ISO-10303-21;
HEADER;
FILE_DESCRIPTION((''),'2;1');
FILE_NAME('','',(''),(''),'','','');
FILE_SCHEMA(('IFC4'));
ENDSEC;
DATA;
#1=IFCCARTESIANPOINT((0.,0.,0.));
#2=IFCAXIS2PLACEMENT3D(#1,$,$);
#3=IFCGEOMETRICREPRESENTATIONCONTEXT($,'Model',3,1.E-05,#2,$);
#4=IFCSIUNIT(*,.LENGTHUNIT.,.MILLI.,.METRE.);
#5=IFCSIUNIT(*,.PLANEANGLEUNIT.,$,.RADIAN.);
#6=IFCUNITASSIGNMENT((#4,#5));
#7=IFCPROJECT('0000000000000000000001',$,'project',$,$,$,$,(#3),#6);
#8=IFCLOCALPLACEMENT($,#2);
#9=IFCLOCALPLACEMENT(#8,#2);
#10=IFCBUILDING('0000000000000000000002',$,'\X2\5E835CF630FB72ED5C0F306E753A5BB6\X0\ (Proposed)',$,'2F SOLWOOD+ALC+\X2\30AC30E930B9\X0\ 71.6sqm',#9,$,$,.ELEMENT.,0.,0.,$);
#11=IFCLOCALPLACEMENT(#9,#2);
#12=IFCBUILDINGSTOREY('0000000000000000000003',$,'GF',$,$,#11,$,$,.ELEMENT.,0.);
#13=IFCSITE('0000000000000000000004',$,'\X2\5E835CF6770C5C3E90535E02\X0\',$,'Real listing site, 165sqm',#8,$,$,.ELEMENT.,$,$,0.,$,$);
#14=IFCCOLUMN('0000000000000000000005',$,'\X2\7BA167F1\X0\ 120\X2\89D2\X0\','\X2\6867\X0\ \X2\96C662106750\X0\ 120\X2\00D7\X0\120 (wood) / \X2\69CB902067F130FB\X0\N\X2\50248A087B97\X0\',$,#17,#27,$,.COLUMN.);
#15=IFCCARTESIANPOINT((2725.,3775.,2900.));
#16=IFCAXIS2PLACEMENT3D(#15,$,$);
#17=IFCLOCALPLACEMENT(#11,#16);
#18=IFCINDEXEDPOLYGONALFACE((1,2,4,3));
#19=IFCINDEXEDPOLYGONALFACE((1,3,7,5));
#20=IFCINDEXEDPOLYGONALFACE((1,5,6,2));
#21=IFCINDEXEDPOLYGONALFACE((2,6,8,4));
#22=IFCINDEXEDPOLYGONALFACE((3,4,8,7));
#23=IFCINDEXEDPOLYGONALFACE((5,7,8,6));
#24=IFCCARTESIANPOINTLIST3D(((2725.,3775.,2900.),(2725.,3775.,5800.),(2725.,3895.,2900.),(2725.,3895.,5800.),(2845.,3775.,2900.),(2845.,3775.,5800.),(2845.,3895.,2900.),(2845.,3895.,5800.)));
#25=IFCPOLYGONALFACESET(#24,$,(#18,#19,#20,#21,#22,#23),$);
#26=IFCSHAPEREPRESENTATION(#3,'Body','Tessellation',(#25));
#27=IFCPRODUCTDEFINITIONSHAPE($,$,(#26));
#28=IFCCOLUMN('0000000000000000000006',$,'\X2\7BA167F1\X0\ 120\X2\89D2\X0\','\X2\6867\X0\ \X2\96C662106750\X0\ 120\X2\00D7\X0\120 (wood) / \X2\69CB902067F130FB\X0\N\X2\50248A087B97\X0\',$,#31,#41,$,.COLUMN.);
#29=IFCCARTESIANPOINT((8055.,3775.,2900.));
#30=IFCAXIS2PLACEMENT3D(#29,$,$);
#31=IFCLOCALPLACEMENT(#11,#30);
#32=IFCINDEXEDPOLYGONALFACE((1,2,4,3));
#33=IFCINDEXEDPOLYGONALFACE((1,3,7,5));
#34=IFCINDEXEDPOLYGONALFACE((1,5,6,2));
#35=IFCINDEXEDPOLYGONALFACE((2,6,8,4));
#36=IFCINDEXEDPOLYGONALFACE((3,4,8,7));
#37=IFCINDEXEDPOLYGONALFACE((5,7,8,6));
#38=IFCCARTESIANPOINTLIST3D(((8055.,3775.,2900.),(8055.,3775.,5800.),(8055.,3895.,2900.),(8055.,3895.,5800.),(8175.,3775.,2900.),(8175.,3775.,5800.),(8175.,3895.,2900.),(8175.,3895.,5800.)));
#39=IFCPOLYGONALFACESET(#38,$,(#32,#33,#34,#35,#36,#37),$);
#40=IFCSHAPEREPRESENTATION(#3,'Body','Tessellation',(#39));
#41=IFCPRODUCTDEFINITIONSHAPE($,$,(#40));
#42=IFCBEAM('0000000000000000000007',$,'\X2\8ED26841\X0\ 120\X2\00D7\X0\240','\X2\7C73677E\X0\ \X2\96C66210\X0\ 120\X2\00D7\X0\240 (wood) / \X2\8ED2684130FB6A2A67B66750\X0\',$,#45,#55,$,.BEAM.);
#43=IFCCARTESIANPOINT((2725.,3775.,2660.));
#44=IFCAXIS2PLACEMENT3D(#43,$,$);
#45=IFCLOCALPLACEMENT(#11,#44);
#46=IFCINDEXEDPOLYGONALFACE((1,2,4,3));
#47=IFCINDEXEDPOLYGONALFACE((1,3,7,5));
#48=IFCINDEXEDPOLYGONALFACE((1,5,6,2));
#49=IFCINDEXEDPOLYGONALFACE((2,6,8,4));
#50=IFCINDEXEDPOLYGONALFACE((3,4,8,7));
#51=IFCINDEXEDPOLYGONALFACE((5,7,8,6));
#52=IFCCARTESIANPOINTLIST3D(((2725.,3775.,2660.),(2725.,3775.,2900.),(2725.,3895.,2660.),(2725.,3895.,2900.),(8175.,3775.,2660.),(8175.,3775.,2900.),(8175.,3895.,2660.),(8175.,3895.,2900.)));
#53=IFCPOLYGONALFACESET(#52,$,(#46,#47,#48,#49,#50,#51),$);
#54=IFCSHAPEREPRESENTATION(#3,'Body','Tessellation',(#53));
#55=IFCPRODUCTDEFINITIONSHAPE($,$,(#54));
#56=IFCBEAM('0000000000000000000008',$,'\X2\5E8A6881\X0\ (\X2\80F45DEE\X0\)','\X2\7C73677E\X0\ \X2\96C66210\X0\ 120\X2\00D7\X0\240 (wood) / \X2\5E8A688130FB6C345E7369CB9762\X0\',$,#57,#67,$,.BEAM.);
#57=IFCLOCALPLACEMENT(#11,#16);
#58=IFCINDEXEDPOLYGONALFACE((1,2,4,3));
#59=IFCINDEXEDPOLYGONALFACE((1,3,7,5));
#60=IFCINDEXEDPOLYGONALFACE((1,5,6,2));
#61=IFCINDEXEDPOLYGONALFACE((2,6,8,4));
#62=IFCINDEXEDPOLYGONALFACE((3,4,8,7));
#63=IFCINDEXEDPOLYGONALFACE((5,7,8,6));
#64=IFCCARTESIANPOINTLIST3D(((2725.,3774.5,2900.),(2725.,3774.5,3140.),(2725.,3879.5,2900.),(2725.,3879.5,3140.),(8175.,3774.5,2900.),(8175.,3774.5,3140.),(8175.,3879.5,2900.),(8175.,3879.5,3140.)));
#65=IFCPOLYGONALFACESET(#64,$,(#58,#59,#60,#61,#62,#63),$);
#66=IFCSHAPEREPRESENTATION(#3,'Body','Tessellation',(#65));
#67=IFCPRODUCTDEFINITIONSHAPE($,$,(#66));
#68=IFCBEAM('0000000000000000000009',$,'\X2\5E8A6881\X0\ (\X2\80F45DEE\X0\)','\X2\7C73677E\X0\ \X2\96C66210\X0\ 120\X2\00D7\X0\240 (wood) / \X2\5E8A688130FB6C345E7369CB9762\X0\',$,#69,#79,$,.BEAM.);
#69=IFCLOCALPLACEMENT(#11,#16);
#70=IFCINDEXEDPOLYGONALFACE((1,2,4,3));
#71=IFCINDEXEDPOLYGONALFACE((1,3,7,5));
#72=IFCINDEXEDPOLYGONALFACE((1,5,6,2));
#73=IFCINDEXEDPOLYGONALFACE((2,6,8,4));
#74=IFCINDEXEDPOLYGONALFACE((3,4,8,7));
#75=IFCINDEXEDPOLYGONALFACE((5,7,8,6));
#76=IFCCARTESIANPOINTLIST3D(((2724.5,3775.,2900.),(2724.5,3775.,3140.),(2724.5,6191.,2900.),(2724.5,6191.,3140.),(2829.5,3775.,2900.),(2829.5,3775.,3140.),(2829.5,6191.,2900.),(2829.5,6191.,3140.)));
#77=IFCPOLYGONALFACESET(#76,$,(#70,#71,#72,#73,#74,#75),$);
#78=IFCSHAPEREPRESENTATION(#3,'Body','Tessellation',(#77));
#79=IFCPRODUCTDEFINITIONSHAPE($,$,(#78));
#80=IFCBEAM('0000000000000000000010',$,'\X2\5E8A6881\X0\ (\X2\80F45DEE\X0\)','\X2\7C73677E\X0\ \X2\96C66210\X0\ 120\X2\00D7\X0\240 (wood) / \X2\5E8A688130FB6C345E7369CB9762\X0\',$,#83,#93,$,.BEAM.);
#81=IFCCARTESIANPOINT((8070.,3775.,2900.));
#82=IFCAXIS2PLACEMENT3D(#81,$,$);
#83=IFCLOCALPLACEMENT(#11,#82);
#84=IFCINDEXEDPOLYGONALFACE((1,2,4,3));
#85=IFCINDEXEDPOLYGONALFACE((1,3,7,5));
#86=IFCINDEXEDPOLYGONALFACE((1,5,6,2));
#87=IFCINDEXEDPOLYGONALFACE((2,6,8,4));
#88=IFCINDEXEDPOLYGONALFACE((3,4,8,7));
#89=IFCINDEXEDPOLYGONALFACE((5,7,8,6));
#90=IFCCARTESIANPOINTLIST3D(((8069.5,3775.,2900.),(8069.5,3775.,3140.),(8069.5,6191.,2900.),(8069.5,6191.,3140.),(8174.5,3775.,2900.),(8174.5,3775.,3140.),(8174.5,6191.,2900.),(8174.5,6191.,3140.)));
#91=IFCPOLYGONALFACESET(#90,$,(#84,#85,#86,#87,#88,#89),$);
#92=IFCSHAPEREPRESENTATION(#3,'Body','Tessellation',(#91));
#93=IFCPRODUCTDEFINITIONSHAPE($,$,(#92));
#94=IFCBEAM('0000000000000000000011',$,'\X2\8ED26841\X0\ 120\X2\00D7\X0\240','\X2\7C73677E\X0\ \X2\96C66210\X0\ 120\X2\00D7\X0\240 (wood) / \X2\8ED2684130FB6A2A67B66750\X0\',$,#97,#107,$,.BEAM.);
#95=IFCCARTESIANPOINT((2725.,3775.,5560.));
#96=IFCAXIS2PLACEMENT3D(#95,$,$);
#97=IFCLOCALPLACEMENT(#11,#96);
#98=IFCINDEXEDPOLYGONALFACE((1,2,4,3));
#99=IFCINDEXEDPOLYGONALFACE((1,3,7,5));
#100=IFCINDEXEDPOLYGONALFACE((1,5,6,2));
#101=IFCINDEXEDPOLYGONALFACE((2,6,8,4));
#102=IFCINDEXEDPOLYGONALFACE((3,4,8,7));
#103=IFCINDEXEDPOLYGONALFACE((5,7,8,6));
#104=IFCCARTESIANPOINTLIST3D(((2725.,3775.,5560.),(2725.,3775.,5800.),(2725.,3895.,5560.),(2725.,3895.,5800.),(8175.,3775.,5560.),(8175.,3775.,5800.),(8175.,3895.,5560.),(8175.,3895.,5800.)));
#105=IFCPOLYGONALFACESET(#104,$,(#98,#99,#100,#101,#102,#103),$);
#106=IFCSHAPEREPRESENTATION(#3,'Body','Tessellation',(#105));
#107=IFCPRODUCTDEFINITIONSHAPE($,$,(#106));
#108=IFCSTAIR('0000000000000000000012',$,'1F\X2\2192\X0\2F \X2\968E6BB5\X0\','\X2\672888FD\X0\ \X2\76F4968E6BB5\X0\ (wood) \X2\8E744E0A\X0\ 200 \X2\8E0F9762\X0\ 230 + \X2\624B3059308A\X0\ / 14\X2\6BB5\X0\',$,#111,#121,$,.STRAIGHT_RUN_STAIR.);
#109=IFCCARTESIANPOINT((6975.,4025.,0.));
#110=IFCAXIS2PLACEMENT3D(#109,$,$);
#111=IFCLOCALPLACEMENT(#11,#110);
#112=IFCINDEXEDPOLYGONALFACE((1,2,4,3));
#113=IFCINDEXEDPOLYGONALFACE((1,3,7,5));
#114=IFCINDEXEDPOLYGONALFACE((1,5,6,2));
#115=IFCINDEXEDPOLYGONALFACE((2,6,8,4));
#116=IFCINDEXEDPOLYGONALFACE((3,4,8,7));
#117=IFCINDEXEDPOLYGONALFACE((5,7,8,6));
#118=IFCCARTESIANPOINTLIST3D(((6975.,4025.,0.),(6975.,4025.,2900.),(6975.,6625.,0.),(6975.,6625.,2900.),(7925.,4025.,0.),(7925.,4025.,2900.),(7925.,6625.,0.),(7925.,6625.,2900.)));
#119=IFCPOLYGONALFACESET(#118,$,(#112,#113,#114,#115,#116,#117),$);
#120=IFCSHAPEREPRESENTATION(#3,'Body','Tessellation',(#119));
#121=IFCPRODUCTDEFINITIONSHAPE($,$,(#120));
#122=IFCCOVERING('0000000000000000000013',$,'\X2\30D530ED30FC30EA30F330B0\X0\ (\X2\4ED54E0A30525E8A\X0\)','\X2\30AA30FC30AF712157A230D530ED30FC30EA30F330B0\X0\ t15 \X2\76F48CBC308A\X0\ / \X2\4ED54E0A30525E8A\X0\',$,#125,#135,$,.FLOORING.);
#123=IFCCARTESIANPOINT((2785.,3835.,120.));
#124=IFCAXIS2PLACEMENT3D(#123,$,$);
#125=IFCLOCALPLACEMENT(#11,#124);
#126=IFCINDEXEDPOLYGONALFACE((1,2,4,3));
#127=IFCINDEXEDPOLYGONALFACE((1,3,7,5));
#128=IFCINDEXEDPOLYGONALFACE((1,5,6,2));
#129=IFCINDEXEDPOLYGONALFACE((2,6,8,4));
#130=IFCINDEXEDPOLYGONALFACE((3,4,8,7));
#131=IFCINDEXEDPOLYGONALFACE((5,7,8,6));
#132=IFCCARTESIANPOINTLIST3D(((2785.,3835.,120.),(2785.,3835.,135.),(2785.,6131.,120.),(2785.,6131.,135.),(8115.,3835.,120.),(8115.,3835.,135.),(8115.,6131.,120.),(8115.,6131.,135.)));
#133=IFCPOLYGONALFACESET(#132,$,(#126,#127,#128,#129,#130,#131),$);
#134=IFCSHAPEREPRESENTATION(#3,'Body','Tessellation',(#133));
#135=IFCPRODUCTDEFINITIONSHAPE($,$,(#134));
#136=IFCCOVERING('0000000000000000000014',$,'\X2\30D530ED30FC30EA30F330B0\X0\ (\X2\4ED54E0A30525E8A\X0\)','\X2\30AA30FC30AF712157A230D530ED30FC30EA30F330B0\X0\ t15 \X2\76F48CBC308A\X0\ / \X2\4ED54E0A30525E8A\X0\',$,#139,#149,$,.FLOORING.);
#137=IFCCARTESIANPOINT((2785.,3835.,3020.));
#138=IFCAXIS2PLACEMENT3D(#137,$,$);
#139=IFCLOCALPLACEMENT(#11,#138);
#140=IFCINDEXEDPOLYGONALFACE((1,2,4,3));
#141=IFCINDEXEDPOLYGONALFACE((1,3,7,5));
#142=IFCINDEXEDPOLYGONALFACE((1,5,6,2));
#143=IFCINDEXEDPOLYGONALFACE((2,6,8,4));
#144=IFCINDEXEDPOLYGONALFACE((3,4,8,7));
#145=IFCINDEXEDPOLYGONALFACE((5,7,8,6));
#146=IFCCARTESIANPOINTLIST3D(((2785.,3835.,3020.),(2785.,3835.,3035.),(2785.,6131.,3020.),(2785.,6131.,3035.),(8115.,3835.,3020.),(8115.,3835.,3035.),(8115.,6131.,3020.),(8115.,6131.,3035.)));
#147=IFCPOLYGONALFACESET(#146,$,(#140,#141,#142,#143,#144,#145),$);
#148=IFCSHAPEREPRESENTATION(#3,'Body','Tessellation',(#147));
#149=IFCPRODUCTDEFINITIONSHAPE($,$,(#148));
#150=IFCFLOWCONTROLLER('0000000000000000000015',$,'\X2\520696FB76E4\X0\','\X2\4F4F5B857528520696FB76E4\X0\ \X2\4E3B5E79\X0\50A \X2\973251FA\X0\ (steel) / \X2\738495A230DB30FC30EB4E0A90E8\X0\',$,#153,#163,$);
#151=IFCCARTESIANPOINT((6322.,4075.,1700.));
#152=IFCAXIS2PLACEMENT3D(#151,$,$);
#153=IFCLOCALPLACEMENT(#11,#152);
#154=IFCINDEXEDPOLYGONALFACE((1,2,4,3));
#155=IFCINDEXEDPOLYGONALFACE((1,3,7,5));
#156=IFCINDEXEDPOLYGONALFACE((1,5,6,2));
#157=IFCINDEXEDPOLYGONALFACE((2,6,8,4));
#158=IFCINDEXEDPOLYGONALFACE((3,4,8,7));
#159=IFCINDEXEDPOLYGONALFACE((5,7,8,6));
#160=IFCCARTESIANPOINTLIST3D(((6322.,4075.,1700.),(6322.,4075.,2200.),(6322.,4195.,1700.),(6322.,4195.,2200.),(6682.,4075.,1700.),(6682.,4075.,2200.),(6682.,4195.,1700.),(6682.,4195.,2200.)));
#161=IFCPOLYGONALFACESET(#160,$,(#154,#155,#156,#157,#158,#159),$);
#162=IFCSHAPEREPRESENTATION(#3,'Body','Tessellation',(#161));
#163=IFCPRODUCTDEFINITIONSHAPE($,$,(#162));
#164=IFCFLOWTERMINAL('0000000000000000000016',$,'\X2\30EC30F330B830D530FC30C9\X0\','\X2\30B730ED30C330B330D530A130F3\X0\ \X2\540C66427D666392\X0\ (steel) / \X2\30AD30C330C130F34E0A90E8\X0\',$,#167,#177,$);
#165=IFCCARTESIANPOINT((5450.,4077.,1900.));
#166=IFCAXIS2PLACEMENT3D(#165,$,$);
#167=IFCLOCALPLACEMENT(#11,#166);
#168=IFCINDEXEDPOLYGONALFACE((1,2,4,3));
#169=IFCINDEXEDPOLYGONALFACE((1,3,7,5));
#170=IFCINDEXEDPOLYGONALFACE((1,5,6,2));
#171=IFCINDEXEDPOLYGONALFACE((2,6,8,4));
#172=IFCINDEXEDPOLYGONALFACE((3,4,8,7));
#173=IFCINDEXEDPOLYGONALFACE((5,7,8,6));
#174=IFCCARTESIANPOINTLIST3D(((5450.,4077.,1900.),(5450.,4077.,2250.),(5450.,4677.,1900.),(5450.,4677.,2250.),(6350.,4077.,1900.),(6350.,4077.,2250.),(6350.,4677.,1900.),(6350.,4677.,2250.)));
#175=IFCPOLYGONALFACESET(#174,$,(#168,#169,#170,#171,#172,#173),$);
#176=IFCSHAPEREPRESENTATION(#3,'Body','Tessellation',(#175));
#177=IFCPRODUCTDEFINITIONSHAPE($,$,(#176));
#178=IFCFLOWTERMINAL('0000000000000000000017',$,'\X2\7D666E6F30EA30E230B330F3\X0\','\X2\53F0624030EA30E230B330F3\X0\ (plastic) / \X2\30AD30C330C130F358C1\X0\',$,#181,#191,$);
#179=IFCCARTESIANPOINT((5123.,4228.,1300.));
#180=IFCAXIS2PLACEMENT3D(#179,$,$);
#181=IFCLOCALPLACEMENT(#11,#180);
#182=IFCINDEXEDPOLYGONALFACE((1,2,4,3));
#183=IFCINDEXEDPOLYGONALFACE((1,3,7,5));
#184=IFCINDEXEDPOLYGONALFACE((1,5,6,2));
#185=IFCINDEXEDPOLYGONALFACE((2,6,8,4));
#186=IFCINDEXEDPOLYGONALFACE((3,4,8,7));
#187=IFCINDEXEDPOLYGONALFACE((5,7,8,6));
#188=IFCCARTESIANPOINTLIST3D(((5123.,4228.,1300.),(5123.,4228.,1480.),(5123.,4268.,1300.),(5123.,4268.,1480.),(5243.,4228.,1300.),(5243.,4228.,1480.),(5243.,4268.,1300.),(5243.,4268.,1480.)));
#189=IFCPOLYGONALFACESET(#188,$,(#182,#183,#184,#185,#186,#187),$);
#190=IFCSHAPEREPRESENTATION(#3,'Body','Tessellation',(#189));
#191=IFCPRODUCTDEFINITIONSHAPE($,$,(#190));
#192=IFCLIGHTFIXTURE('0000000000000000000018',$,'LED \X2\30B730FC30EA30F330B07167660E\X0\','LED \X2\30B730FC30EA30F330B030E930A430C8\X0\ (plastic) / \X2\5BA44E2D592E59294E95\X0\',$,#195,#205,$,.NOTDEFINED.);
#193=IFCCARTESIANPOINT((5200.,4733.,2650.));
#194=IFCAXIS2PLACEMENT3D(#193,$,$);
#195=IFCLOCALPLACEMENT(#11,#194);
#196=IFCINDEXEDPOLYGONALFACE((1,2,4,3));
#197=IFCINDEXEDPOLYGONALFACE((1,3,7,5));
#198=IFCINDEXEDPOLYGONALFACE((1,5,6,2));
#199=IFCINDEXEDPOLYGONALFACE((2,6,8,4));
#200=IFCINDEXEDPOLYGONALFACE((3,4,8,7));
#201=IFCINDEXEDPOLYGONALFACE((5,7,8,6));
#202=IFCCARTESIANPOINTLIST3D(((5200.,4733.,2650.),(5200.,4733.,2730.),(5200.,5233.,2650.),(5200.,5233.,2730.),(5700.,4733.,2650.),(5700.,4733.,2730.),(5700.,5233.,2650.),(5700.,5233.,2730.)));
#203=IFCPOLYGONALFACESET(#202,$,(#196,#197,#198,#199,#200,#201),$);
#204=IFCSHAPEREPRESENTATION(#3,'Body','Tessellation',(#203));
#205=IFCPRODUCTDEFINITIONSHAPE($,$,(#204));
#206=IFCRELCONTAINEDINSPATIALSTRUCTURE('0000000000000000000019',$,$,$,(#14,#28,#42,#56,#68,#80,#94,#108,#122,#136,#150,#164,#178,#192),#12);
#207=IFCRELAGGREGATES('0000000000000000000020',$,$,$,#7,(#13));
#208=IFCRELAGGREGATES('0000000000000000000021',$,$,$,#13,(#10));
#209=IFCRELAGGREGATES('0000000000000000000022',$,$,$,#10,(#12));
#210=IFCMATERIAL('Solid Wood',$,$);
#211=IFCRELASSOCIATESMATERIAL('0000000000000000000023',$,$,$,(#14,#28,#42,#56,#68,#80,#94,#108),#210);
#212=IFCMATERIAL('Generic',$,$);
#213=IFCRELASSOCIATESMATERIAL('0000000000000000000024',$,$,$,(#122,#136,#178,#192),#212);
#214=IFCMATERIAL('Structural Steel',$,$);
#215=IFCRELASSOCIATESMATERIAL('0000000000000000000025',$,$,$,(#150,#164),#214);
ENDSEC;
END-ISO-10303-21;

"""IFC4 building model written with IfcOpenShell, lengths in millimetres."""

from ifc_helpers import new_model, si_unit, frame, frame_2d, origin, place, context, project, spatial, rectangle, extrude, material, element, save


model = new_model("IFC4")

# Units and contexts
model_context = context("Model", 3, precision=1e-05, world=origin())
ifc_project = project(units=[si_unit("LENGTHUNIT", "METRE", prefix="MILLI"), si_unit("PLANEANGLEUNIT", "RADIAN")], contexts=[model_context])

# Site, building, storey
site_placement = place(None, origin())
site = spatial("IfcSite", under=ifc_project, at=site_placement, Name="広島県尾道市", ObjectType="Real listing site, 165sqm", CompositionType="ELEMENT", RefElevation=0.0)
building_placement = place(site_placement, origin())
building = spatial("IfcBuilding", under=site, at=building_placement, Name="広島・狭小の町家 (Proposed)", ObjectType="2F SOLWOOD+ALC+ガラス 71.6sqm", CompositionType="ELEMENT", ElevationOfRefHeight=0.0, ElevationOfTerrain=0.0)
storey_placement = place(building_placement, origin())
storey = spatial("IfcBuildingStorey", under=building, at=storey_placement, Name="GF", CompositionType="ELEMENT", Elevation=0.0)

# Columns
ifc_material_1 = material(Name="Solid Wood")
column_1_placement = place(storey_placement, frame((2725.0, 3775.0, 2900.0)))
element("IfcColumn", 1, at=column_1_placement, inside=storey, material=ifc_material_1, Name="管柱 120角", Description="桧 集成材 120×120 (wood) / 構造柱・N値計算", PredefinedType="COLUMN", context=model_context, shape_type="SweptSolid", body=[
    extrude(rectangle(XDim=120.0, YDim=120.0, at=frame_2d((60.0, 60.0))), frame((2725.0, 3775.0, 2900.0)), (0.0, 0.0, 1.0), 2900.0),
])
column_2_placement = place(storey_placement, frame((8055.0, 3775.0, 2900.0)))
element("IfcColumn", 2, at=column_2_placement, inside=storey, material=ifc_material_1, Name="管柱 120角", Description="桧 集成材 120×120 (wood) / 構造柱・N値計算", PredefinedType="COLUMN", context=model_context, shape_type="SweptSolid", body=[
    extrude(rectangle(XDim=120.0, YDim=120.0, at=frame_2d((60.0, 60.0))), frame((8055.0, 3775.0, 2900.0)), (0.0, 0.0, 1.0), 2900.0),
])

# Beams
beam_1_placement = place(storey_placement, frame((2725.0, 3775.0, 2660.0)))
element("IfcBeam", 3, at=beam_1_placement, inside=storey, material=ifc_material_1, Name="軒桁 120×240", Description="米松 集成 120×240 (wood) / 軒桁・横架材", PredefinedType="BEAM", context=model_context, shape_type="SweptSolid", body=[
    extrude(rectangle(XDim=5450.0, YDim=120.0, at=frame_2d((2725.0, 60.0))), frame((2725.0, 3775.0, 2660.0)), (0.0, 0.0, 1.0), 240.0),
])
beam_2_placement = place(storey_placement, frame((2725.0, 3775.0, 2900.0)))
element("IfcBeam", 4, at=beam_2_placement, inside=storey, material=ifc_material_1, Name="床梁 (胴差)", Description="米松 集成 120×240 (wood) / 床梁・水平構面", PredefinedType="BEAM", context=model_context, shape_type="SweptSolid", body=[
    extrude(rectangle(XDim=5450.0, YDim=105.0, at=frame_2d((2725.0, 52.0))), frame((2725.0, 3775.0, 2900.0)), (0.0, 0.0, 1.0), 240.0),
])
beam_3_placement = place(storey_placement, frame((2725.0, 3775.0, 2900.0)))
element("IfcBeam", 5, at=beam_3_placement, inside=storey, material=ifc_material_1, Name="床梁 (胴差)", Description="米松 集成 120×240 (wood) / 床梁・水平構面", PredefinedType="BEAM", context=model_context, shape_type="SweptSolid", body=[
    extrude(rectangle(XDim=105.0, YDim=2416.0, at=frame_2d((52.0, 1208.0))), frame((2725.0, 3775.0, 2900.0)), (0.0, 0.0, 1.0), 240.0),
])
beam_4_placement = place(storey_placement, frame((8070.0, 3775.0, 2900.0)))
element("IfcBeam", 6, at=beam_4_placement, inside=storey, material=ifc_material_1, Name="床梁 (胴差)", Description="米松 集成 120×240 (wood) / 床梁・水平構面", PredefinedType="BEAM", context=model_context, shape_type="SweptSolid", body=[
    extrude(rectangle(XDim=105.0, YDim=2416.0, at=frame_2d((52.0, 1208.0))), frame((8070.0, 3775.0, 2900.0)), (0.0, 0.0, 1.0), 240.0),
])
beam_5_placement = place(storey_placement, frame((2725.0, 3775.0, 5560.0)))
element("IfcBeam", 7, at=beam_5_placement, inside=storey, material=ifc_material_1, Name="軒桁 120×240", Description="米松 集成 120×240 (wood) / 軒桁・横架材", PredefinedType="BEAM", context=model_context, shape_type="SweptSolid", body=[
    extrude(rectangle(XDim=5450.0, YDim=120.0, at=frame_2d((2725.0, 60.0))), frame((2725.0, 3775.0, 5560.0)), (0.0, 0.0, 1.0), 240.0),
])

# Stair
stair_placement = place(storey_placement, frame((6975.0, 4025.0, 0.0)))
element("IfcStair", 8, at=stair_placement, inside=storey, material=ifc_material_1, Name="1F→2F 階段", Description="木製 直階段 (wood) 蹴上 200 踏面 230 + 手すり / 14段", PredefinedType="STRAIGHT_RUN_STAIR", context=model_context, shape_type="SweptSolid", body=[
    extrude(rectangle(XDim=950.0, YDim=2600.0, at=frame_2d((475.0, 1300.0))), frame((6975.0, 4025.0, 0.0)), (0.0, 0.0, 1.0), 2900.0),
])

# Coverings
ifc_material_2 = material(Name="Generic")
covering_1_placement = place(storey_placement, frame((2785.0, 3835.0, 120.0)))
element("IfcCovering", 9, at=covering_1_placement, inside=storey, material=ifc_material_2, Name="フローリング (仕上げ床)", Description="オーク無垢フローリング t15 直貼り / 仕上げ床", PredefinedType="FLOORING", context=model_context, shape_type="SweptSolid", body=[
    extrude(rectangle(XDim=5330.0, YDim=2296.0, at=frame_2d((2665.0, 1148.0))), frame((2785.0, 3835.0, 120.0)), (0.0, 0.0, 1.0), 15.0),
])
covering_2_placement = place(storey_placement, frame((2785.0, 3835.0, 3020.0)))
element("IfcCovering", 10, at=covering_2_placement, inside=storey, material=ifc_material_2, Name="フローリング (仕上げ床)", Description="オーク無垢フローリング t15 直貼り / 仕上げ床", PredefinedType="FLOORING", context=model_context, shape_type="SweptSolid", body=[
    extrude(rectangle(XDim=5330.0, YDim=2296.0, at=frame_2d((2665.0, 1148.0))), frame((2785.0, 3835.0, 3020.0)), (0.0, 0.0, 1.0), 15.0),
])

# Flow controller
ifc_material_3 = material(Name="Structural Steel")
flow_controller_placement = place(storey_placement, frame((6322.0, 4075.0, 1700.0)))
element("IfcFlowController", 11, at=flow_controller_placement, inside=storey, material=ifc_material_3, Name="分電盤", Description="住宅用分電盤 主幹50A 露出 (steel) / 玄関ホール上部", context=model_context, shape_type="SweptSolid", body=[
    extrude(rectangle(XDim=360.0, YDim=120.0, at=frame_2d((180.0, 60.0))), frame((6322.0, 4075.0, 1700.0)), (0.0, 0.0, 1.0), 500.0),
])

# Flow terminals
flow_terminal_1_placement = place(storey_placement, frame((5450.0, 4077.0, 1900.0)))
element("IfcFlowTerminal", 12, at=flow_terminal_1_placement, inside=storey, material=ifc_material_3, Name="レンジフード", Description="シロッコファン 同時給排 (steel) / キッチン上部", context=model_context, shape_type="SweptSolid", body=[
    extrude(rectangle(XDim=900.0, YDim=600.0, at=frame_2d((450.0, 300.0))), frame((5450.0, 4077.0, 1900.0)), (0.0, 0.0, 1.0), 350.0),
])
flow_terminal_2_placement = place(storey_placement, frame((5123.0, 4228.0, 1300.0)))
element("IfcFlowTerminal", 13, at=flow_terminal_2_placement, inside=storey, material=ifc_material_2, Name="給湯リモコン", Description="台所リモコン (plastic) / キッチン壁", context=model_context, shape_type="SweptSolid", body=[
    extrude(rectangle(XDim=120.0, YDim=40.0, at=frame_2d((60.0, 20.0))), frame((5123.0, 4228.0, 1300.0)), (0.0, 0.0, 1.0), 180.0),
])

# Light fixture
light_fixture_1_placement = place(storey_placement, frame((5200.0, 4733.0, 2650.0)))
element("IfcLightFixture", 14, at=light_fixture_1_placement, inside=storey, material=ifc_material_2, Name="LED シーリング照明", Description="LED シーリングライト (plastic) / 室中央天井", PredefinedType="NOTDEFINED", context=model_context, shape_type="SweptSolid", body=[
    extrude(rectangle(XDim=500.0, YDim=500.0, at=frame_2d((250.0, 250.0))), frame((5200.0, 4733.0, 2650.0)), (0.0, 0.0, 1.0), 80.0),
])

save(model, "model.ifc")
